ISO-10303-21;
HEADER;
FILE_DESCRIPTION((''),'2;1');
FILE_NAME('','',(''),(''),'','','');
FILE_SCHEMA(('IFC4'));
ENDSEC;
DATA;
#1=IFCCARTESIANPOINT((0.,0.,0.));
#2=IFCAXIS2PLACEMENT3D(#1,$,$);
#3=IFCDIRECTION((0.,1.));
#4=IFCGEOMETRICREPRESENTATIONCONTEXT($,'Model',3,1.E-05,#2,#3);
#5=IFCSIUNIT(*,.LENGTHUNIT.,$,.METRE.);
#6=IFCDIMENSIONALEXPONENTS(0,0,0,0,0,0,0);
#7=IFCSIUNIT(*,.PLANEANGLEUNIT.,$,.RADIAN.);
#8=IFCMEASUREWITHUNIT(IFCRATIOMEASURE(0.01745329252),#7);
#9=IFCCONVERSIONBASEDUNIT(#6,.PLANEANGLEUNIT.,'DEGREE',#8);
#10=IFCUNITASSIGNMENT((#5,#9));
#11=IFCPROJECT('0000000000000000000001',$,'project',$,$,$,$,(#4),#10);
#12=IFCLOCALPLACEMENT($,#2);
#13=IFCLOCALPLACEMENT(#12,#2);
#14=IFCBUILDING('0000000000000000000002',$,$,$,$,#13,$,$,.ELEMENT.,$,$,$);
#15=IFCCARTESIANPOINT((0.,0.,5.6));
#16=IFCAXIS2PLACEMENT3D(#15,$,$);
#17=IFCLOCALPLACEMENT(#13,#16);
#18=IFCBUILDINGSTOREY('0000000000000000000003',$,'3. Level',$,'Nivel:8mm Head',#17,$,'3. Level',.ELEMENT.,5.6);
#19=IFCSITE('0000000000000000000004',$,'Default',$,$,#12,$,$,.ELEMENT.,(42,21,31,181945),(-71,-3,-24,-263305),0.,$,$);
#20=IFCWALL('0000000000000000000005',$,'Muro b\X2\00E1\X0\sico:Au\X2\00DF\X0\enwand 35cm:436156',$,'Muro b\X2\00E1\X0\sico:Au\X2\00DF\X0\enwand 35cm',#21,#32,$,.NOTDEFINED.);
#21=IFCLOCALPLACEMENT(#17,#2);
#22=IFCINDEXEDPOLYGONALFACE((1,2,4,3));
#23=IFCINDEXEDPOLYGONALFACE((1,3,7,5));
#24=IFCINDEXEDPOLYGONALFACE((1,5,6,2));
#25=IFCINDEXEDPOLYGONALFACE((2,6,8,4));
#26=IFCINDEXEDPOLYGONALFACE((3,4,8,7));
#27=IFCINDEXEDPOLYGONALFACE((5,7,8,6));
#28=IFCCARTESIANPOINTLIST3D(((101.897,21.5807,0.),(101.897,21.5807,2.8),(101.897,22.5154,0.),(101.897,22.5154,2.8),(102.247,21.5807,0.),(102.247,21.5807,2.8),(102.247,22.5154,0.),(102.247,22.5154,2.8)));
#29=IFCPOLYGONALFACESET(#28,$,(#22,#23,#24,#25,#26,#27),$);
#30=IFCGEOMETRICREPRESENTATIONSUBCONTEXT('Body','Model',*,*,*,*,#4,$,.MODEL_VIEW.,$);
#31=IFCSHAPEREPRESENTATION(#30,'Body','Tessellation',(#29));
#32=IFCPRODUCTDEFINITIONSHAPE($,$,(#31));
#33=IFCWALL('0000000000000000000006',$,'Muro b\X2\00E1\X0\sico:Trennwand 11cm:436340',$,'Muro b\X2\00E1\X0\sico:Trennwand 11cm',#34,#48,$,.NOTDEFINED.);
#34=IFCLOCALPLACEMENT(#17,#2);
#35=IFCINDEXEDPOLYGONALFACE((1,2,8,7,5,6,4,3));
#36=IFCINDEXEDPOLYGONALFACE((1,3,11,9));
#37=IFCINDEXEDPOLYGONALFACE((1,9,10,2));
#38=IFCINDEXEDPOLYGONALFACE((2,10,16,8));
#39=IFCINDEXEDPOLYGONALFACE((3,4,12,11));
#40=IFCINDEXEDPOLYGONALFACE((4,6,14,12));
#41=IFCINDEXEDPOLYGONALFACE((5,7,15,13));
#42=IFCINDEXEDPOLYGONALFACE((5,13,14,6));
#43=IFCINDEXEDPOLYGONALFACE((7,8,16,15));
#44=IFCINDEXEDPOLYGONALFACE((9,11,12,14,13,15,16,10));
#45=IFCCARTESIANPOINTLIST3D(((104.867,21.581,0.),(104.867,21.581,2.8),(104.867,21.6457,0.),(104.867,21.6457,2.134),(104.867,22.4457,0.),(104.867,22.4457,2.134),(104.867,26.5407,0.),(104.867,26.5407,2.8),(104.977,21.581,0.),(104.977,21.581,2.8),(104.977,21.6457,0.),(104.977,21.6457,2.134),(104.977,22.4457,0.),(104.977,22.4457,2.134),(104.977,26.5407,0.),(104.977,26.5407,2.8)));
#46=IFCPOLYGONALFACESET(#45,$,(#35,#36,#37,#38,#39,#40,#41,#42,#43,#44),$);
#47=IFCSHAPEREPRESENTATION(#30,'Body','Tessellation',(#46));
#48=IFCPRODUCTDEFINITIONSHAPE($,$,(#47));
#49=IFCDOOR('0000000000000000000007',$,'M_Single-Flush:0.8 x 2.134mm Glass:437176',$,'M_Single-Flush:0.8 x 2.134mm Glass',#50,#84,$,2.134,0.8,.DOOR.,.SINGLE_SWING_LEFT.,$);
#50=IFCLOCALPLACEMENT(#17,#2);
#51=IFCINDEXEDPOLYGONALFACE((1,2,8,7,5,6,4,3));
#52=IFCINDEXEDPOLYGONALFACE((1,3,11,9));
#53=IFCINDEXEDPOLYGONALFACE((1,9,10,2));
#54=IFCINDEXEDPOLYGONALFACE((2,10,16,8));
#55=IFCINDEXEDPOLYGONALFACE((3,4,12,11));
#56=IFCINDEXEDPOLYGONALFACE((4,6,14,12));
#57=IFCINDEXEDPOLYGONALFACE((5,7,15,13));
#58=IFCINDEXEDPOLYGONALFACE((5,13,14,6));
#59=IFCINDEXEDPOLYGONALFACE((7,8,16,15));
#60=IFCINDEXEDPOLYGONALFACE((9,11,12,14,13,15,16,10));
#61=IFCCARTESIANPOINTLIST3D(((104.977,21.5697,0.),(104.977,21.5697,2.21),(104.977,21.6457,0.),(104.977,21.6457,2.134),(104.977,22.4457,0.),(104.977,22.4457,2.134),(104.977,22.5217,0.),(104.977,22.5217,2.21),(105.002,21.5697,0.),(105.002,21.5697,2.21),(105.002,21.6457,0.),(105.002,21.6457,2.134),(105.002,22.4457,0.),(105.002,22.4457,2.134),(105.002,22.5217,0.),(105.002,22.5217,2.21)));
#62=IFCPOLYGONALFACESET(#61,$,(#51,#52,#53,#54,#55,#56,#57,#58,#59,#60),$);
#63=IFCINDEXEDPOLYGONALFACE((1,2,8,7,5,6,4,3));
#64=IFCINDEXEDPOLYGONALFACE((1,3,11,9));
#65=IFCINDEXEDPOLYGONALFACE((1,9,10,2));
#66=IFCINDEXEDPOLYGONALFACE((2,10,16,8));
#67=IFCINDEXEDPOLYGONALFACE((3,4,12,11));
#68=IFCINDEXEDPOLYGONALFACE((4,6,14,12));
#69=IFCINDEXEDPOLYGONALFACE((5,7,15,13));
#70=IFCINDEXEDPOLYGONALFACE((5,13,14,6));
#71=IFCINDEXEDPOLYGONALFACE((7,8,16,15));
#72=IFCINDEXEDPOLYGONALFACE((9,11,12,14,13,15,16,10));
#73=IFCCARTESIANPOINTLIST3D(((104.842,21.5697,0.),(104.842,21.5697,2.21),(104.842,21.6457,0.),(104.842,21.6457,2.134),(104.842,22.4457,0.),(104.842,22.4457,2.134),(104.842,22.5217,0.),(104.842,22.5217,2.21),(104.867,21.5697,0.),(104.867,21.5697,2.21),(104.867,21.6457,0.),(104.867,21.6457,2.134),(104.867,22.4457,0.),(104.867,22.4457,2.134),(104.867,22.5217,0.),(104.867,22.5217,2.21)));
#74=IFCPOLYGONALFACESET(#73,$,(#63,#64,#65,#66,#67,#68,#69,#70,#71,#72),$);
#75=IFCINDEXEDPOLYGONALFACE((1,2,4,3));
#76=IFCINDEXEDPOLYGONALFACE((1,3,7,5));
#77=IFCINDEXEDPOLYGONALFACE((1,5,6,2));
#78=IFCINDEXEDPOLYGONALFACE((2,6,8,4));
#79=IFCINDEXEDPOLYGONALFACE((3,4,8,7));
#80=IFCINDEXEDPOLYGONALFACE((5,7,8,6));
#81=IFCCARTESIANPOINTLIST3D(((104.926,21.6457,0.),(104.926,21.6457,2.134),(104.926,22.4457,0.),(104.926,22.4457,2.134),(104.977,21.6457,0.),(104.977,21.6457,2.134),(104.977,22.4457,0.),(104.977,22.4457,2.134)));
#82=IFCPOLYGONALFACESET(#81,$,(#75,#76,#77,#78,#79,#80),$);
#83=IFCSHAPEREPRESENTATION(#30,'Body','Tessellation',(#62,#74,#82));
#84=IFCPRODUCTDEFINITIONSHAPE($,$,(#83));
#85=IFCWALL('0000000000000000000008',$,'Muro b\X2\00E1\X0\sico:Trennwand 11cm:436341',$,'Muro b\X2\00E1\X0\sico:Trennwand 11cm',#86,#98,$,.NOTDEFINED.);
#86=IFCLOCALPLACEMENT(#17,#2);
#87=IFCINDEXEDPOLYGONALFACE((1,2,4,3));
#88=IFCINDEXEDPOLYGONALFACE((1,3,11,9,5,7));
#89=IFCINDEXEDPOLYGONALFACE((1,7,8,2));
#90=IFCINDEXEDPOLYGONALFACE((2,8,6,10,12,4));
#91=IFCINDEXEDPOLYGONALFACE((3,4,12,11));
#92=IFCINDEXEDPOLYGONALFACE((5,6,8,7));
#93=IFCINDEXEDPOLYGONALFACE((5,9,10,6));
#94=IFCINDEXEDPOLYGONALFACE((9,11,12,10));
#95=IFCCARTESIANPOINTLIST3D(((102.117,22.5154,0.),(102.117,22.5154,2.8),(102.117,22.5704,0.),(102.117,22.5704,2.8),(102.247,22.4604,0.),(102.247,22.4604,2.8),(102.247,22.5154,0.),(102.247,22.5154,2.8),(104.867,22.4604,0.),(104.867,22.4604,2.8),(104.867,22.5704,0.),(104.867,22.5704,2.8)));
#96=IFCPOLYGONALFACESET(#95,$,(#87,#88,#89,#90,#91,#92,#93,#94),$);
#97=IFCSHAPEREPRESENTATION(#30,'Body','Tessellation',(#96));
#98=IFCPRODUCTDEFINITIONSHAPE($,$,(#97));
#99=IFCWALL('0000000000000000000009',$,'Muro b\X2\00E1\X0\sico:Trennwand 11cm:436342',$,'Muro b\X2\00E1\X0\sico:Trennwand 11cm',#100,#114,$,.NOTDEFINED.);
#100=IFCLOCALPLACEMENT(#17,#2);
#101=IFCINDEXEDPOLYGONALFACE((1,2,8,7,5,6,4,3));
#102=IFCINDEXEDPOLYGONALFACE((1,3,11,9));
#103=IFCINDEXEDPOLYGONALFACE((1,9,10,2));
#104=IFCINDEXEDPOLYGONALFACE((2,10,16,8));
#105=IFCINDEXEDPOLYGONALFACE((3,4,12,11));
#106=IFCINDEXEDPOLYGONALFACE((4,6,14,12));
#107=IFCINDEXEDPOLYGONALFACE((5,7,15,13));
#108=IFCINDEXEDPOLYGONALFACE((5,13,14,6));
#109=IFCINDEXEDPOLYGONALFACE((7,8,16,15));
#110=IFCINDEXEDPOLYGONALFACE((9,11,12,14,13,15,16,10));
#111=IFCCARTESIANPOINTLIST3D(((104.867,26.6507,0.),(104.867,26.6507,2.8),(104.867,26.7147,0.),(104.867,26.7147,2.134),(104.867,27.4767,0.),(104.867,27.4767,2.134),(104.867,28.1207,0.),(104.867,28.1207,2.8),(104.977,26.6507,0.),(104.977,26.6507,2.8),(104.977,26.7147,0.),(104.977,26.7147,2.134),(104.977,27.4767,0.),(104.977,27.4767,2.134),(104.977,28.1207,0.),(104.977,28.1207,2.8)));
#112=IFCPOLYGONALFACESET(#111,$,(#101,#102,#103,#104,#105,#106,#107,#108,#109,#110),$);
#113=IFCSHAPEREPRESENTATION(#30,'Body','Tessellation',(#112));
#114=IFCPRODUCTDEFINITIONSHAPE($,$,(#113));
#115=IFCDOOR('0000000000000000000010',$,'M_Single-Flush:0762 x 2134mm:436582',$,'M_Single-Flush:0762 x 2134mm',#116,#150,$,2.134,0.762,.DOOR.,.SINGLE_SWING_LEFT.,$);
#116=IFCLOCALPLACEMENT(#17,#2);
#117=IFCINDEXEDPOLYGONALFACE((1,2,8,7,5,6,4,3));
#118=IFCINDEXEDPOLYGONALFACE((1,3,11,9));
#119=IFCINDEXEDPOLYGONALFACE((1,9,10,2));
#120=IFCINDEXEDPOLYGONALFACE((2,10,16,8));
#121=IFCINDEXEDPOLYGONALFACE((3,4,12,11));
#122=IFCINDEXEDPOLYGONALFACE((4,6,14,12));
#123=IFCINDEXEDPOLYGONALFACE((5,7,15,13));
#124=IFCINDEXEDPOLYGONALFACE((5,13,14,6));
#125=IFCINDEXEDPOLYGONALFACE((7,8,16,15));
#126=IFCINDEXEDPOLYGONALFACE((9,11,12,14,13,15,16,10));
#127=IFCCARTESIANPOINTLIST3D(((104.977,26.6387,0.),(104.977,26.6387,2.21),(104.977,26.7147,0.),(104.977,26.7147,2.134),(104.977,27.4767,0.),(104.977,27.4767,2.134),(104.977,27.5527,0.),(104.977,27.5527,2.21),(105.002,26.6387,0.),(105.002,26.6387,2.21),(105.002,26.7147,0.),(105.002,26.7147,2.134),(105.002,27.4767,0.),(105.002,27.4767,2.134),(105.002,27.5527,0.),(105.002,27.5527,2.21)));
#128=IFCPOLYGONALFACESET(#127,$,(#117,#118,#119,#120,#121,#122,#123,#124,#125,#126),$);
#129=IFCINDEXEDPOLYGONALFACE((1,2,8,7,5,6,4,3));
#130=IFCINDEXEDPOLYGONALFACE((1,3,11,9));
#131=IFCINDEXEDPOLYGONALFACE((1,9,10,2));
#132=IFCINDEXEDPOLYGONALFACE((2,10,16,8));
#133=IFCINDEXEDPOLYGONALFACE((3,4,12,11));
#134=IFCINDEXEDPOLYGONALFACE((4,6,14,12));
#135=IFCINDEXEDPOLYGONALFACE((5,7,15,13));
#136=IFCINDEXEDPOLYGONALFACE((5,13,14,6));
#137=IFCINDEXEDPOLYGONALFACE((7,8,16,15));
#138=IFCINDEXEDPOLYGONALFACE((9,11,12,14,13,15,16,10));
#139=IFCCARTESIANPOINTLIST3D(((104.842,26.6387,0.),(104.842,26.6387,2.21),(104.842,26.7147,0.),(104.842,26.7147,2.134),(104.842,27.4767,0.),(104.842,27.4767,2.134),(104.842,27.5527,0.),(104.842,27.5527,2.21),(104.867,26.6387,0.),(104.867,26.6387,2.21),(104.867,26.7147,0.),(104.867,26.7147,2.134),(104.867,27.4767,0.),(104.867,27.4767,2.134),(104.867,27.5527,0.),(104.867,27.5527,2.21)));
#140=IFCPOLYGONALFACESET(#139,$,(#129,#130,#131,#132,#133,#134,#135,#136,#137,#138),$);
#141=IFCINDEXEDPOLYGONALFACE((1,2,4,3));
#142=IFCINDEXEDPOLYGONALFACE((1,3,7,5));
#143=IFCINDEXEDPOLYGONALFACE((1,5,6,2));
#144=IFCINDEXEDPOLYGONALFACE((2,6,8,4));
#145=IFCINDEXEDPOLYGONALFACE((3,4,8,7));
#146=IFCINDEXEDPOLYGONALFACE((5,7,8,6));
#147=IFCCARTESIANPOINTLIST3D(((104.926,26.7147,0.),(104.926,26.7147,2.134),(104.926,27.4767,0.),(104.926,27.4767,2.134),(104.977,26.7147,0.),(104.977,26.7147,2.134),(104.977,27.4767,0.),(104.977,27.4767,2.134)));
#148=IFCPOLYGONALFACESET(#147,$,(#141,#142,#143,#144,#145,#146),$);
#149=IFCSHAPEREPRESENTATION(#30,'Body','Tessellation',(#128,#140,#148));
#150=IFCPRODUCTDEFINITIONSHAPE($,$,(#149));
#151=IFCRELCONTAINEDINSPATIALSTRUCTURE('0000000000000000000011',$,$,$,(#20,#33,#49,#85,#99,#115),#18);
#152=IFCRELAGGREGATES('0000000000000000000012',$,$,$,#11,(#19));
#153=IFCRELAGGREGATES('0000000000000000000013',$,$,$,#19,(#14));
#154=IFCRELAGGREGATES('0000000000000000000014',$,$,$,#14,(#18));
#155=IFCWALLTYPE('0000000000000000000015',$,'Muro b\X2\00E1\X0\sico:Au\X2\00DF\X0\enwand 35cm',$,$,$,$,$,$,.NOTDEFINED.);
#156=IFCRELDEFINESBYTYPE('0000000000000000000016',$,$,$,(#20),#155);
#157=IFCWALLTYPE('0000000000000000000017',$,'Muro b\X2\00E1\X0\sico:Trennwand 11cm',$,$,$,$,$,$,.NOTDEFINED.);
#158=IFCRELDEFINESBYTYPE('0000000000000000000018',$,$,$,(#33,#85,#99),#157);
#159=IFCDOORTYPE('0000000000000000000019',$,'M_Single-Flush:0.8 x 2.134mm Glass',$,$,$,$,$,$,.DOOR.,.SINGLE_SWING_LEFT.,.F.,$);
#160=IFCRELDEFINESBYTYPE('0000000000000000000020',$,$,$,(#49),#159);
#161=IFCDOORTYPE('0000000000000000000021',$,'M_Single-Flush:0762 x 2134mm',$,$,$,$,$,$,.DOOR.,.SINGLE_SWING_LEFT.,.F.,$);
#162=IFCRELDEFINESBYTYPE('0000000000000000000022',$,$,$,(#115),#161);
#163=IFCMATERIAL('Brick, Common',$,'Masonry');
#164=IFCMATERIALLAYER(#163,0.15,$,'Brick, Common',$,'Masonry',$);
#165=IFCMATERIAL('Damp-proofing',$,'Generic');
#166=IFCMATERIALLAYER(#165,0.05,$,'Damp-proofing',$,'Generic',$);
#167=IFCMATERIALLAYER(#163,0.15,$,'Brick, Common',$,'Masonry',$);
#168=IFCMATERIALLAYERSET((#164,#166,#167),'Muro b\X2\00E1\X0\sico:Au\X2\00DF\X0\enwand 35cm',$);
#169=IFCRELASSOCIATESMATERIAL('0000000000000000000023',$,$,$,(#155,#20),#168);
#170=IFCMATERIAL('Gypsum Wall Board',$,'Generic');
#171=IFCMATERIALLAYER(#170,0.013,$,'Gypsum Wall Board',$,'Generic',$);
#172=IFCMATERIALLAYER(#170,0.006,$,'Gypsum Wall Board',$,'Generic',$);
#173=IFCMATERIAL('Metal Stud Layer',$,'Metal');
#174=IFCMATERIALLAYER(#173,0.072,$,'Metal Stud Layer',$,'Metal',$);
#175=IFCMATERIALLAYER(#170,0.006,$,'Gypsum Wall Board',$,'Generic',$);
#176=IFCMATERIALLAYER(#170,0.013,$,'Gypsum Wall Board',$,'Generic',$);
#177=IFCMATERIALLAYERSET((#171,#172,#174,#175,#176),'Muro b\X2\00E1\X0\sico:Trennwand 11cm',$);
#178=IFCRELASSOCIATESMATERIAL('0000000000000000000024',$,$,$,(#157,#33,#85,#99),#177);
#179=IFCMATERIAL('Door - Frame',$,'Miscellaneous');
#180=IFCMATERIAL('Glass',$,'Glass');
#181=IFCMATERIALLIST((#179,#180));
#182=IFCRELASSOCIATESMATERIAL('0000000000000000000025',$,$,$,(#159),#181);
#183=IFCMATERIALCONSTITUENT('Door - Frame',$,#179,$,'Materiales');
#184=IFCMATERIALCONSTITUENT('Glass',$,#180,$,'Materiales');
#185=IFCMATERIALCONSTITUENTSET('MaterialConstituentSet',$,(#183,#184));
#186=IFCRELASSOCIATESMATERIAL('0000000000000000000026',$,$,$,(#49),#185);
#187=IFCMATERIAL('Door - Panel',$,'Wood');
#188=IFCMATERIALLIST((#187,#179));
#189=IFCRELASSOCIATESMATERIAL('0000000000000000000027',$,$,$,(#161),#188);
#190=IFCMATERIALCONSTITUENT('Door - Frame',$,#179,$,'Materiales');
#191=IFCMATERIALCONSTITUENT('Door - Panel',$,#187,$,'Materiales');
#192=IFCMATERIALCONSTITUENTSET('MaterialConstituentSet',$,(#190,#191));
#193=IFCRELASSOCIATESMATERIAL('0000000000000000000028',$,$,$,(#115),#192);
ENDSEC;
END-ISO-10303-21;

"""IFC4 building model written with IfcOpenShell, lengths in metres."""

from ifc_helpers import new_model, entity, si_unit, converted_unit, direction, frame, frame_2d, origin, origin_2d_with_axis, place, context, subcontext, project, spatial, polyline, rectangle, outline, extrude, source, transform, mapped, material, material_list, layer, layer_set, layer_usage, constituent, constituent_set, type_object, type_shapes, element, fill, save


model = new_model("IFC4")

# Units and contexts
model_context = context("Model", 3, precision=1e-05, world=origin(), true_north=direction((0.0, 1.0)))
body_context = subcontext(model_context, "Body", "Model", "MODEL_VIEW")
ifc_project = project(units=[si_unit("LENGTHUNIT", "METRE"), converted_unit("PLANEANGLEUNIT", "DEGREE", entity("IfcRatioMeasure", 0.01745329252), si_unit("PLANEANGLEUNIT", "RADIAN"), dimensions=[0, 0, 0, 0, 0, 0, 0])], contexts=[model_context])

# Site, building, storey
site_placement = place(None, origin())
site = spatial("IfcSite", under=ifc_project, at=site_placement, Name="Default", CompositionType="ELEMENT", RefLatitude=(42, 21, 31, 181945), RefLongitude=(-71, -3, -24, -263305), RefElevation=0.0)
building_placement = place(site_placement, origin())
building = spatial("IfcBuilding", under=site, at=building_placement, CompositionType="ELEMENT")
storey_placement = place(building_placement, frame((0.0, 0.0, 5.6)))
storey = spatial("IfcBuildingStorey", under=building, at=storey_placement, Name="3. Level", ObjectType="Nivel:8mm Head", LongName="3. Level", CompositionType="ELEMENT", Elevation=5.6)

# Wall
ifc_material_1 = material(Name="Brick, Common", Category="Masonry")
ifc_layer_1 = layer(ifc_material_1, 0.15, Name="Brick, Common", Category="Masonry")
ifc_material_2 = material(Name="Damp-proofing", Category="Generic")
ifc_layer_2 = layer(ifc_material_2, 0.05, Name="Damp-proofing", Category="Generic")
ifc_layer_3 = layer(ifc_material_1, 0.15, Name="Brick, Common", Category="Masonry")
ifc_layer_set_1 = layer_set([ifc_layer_1, ifc_layer_2, ifc_layer_3], Name="Muro básico:Außenwand 35cm")
ifc_layer_usage_1 = layer_usage(ifc_layer_set_1, "AXIS2", "NEGATIVE", 0.175)
wall_type_1 = type_object("IfcWallType", Name="Muro básico:Außenwand 35cm", PredefinedType="NOTDEFINED", material=ifc_layer_set_1)
wall_1_placement = place(storey_placement, frame((102.072, 21.5807, 0.0), z_axis=(0.0, 0.0, 1.0), x_axis=(0.0, 1.0, 0.0)))
element("IfcWall", 1, at=wall_1_placement, inside=storey, type_object=wall_type_1, material=ifc_layer_usage_1, Name="Muro básico:Außenwand 35cm:436156", ObjectType="Muro básico:Außenwand 35cm", PredefinedType="NOTDEFINED", context=body_context, shape_type="SweptSolid", body=[
    extrude(rectangle(XDim=0.9347, YDim=0.35, at=frame_2d((0.4673, 0.0), x_axis=(-1.0, 0.0))), origin(), (0.0, 0.0, 1.0), 2.8),
])

# Wall, opening, door
ifc_material_3 = material(Name="Gypsum Wall Board", Category="Generic")
ifc_layer_4 = layer(ifc_material_3, 0.013, Name="Gypsum Wall Board", Category="Generic")
ifc_layer_5 = layer(ifc_material_3, 0.006, Name="Gypsum Wall Board", Category="Generic")
ifc_material_4 = material(Name="Metal Stud Layer", Category="Metal")
ifc_layer_6 = layer(ifc_material_4, 0.072, Name="Metal Stud Layer", Category="Metal")
ifc_layer_7 = layer(ifc_material_3, 0.006, Name="Gypsum Wall Board", Category="Generic")
ifc_layer_8 = layer(ifc_material_3, 0.013, Name="Gypsum Wall Board", Category="Generic")
ifc_layer_set_2 = layer_set([ifc_layer_4, ifc_layer_5, ifc_layer_6, ifc_layer_7, ifc_layer_8], Name="Muro básico:Trennwand 11cm")
ifc_layer_usage_2 = layer_usage(ifc_layer_set_2, "AXIS2", "NEGATIVE", 0.055)
wall_type_2 = type_object("IfcWallType", Name="Muro básico:Trennwand 11cm", PredefinedType="NOTDEFINED", material=ifc_layer_set_2)
wall_2_placement = place(storey_placement, frame((104.922, 26.5407, 0.0), z_axis=(0.0, 0.0, 1.0), x_axis=(0.0, -1.0, 0.0)))
wall_2 = element("IfcWall", 2, at=wall_2_placement, inside=storey, type_object=wall_type_2, material=ifc_layer_usage_2, Name="Muro básico:Trennwand 11cm:436340", ObjectType="Muro básico:Trennwand 11cm", PredefinedType="NOTDEFINED", context=body_context, shape_type="SweptSolid", body=[
    extrude(rectangle(XDim=4.9597, YDim=0.11, at=frame_2d((2.4798, 0.0), x_axis=(-1.0, 0.0))), origin(), (0.0, 0.0, 1.0), 2.8),
])
opening_1_placement = place(wall_2_placement, frame((4.095, -0.055, 0.0)))
opening_1 = element("IfcOpeningElement", 3, at=opening_1_placement, cuts=wall_2, ObjectType="Opening", PredefinedType="OPENING", context=body_context, shape_type="SweptSolid", body=[
    extrude(rectangle(XDim=0.8, YDim=2.134, at=frame_2d((1.067, 0.4), x_axis=(0.0, -1.0))), frame((0.0, 0.0, 0.0), z_axis=(0.0, 1.0, 0.0), x_axis=(0.0, 0.0, 1.0)), (0.0, 0.0, 1.0), 0.11),
])
ifc_material_5 = material(Name="Door - Frame", Category="Miscellaneous")
ifc_constituent_1 = constituent(ifc_material_5, Name="Door - Frame", Category="Materiales")
ifc_material_6 = material(Name="Glass", Category="Glass")
ifc_constituent_2 = constituent(ifc_material_6, Name="Glass", Category="Materiales")
ifc_constituent_set_1 = constituent_set(constituents=[ifc_constituent_1, ifc_constituent_2], Name="MaterialConstituentSet")
ifc_material_list_1 = material_list([ifc_material_5, ifc_material_6])
door_type_1 = type_object("IfcDoorType", Name="M_Single-Flush:0.8 x 2.134mm Glass", OperationType="SINGLE_SWING_LEFT", ParameterTakesPrecedence=False, PredefinedType="DOOR", material=ifc_material_list_1)
shared_shape_1 = source(origin(), body_context, "Body", "SweptSolid", [
    extrude(outline(polyline([(-0.476, -1.124), (0.476, -1.124), (0.476, 1.086), (0.4, 1.086), (0.4, -1.048), (-0.4, -1.048), (-0.4, 1.086), (-0.476, 1.086), (-0.476, -1.124)])), frame((0.4, 0.135, 1.086), z_axis=(0.0, -1.0, 0.0), x_axis=(-1.0, 0.0, 0.0)), (0.0, 0.0, 1.0), 0.025),
    extrude(outline(polyline([(-1.124, -0.476), (1.086, -0.476), (1.086, -0.4), (-1.048, -0.4), (-1.048, 0.4), (1.086, 0.4), (1.086, 0.476), (-1.124, 0.476), (-1.124, -0.476)])), frame((0.4, 0.0, 1.086), z_axis=(0.0, -1.0, 0.0), x_axis=(0.0, 0.0, -1.0)), (0.0, 0.0, 1.0), 0.025),
    extrude(rectangle(XDim=0.8, YDim=0.051, at=origin_2d_with_axis()), frame((0.4, 0.0845, 0.0)), (0.0, 0.0, 1.0), 2.134),
])
type_shapes(door_type_1, [shared_shape_1])
door_1_placement = place(opening_1_placement, origin())
door_1 = element("IfcDoor", 4, at=door_1_placement, inside=storey, type_object=door_type_1, material=ifc_constituent_set_1, Name="M_Single-Flush:0.8 x 2.134mm Glass:437176", ObjectType="M_Single-Flush:0.8 x 2.134mm Glass", OperationType="SINGLE_SWING_LEFT", OverallHeight=2.134, OverallWidth=0.8, PredefinedType="DOOR", context=body_context, shape_type="MappedRepresentation", body=[
    mapped(shared_shape_1, transform((0.0, 0.0, 0.0), scale=1.0)),
])
fill(opening_1, door_1)

# Wall
ifc_layer_usage_3 = layer_usage(ifc_layer_set_2, "AXIS2", "NEGATIVE", 0.055)
wall_3_placement = place(storey_placement, frame((104.867, 22.5154, 0.0), z_axis=(0.0, 0.0, 1.0), x_axis=(-1.0, 0.0, 0.0)))
element("IfcWall", 5, at=wall_3_placement, inside=storey, type_object=wall_type_2, material=ifc_layer_usage_3, Name="Muro básico:Trennwand 11cm:436341", ObjectType="Muro básico:Trennwand 11cm", PredefinedType="NOTDEFINED", context=body_context, shape_type="SweptSolid", body=[
    extrude(outline(polyline([(2.75, -0.055), (2.75, 0.0), (2.62, 0.0), (2.62, 0.055), (0.0, 0.055), (0.0, -0.055), (2.75, -0.055)])), origin(), (0.0, 0.0, 1.0), 2.8),
])

# Wall, opening, door
ifc_layer_usage_4 = layer_usage(ifc_layer_set_2, "AXIS2", "NEGATIVE", 0.055)
wall_4_placement = place(storey_placement, frame((104.922, 26.6507, 0.0), z_axis=(0.0, 0.0, 1.0), x_axis=(0.0, 1.0, 0.0)))
wall_4 = element("IfcWall", 6, at=wall_4_placement, inside=storey, type_object=wall_type_2, material=ifc_layer_usage_4, Name="Muro básico:Trennwand 11cm:436342", ObjectType="Muro básico:Trennwand 11cm", PredefinedType="NOTDEFINED", context=body_context, shape_type="SweptSolid", body=[
    extrude(rectangle(XDim=1.47, YDim=0.11, at=frame_2d((0.735, 0.0), x_axis=(-1.0, 0.0))), origin(), (0.0, 0.0, 1.0), 2.8),
])
opening_2_placement = place(wall_4_placement, frame((0.826, 0.055, 0.0)))
opening_2 = element("IfcOpeningElement", 7, at=opening_2_placement, cuts=wall_4, ObjectType="Opening", PredefinedType="OPENING", context=body_context, shape_type="SweptSolid", body=[
    extrude(rectangle(XDim=0.762, YDim=2.134, at=frame_2d((1.067, 0.381), x_axis=(0.0, -1.0))), frame((0.0, 0.0, 0.0), z_axis=(0.0, -1.0, 0.0), x_axis=(0.0, 0.0, 1.0)), (0.0, 0.0, 1.0), 0.11),
])
ifc_constituent_3 = constituent(ifc_material_5, Name="Door - Frame", Category="Materiales")
ifc_material_7 = material(Name="Door - Panel", Category="Wood")
ifc_constituent_4 = constituent(ifc_material_7, Name="Door - Panel", Category="Materiales")
ifc_constituent_set_2 = constituent_set(constituents=[ifc_constituent_3, ifc_constituent_4], Name="MaterialConstituentSet")
ifc_material_list_2 = material_list([ifc_material_7, ifc_material_5])
door_type_2 = type_object("IfcDoorType", Name="M_Single-Flush:0762 x 2134mm", OperationType="SINGLE_SWING_LEFT", ParameterTakesPrecedence=False, PredefinedType="DOOR", material=ifc_material_list_2)
shared_shape_2 = source(origin(), body_context, "Body", "SweptSolid", [
    extrude(outline(polyline([(-0.457, -1.124), (0.457, -1.124), (0.457, 1.086), (0.381, 1.086), (0.381, -1.048), (-0.381, -1.048), (-0.381, 1.086), (-0.457, 1.086), (-0.457, -1.124)])), frame((0.381, 0.135, 1.086), z_axis=(0.0, -1.0, 0.0), x_axis=(-1.0, 0.0, 0.0)), (0.0, 0.0, 1.0), 0.025),
    extrude(outline(polyline([(-1.124, -0.457), (1.086, -0.457), (1.086, -0.381), (-1.048, -0.381), (-1.048, 0.381), (1.086, 0.381), (1.086, 0.457), (-1.124, 0.457), (-1.124, -0.457)])), frame((0.381, 0.0, 1.086), z_axis=(0.0, -1.0, 0.0), x_axis=(0.0, 0.0, -1.0)), (0.0, 0.0, 1.0), 0.025),
    extrude(rectangle(XDim=0.762, YDim=0.051, at=origin_2d_with_axis()), frame((0.381, 0.0845, 0.0)), (0.0, 0.0, 1.0), 2.134),
])
type_shapes(door_type_2, [shared_shape_2])
door_2_placement = place(opening_2_placement, frame((0.0, 0.0, 0.0), z_axis=(0.0, 0.0, 1.0), x_axis=(-1.0, 0.0, 0.0)))
door_2 = element("IfcDoor", 8, at=door_2_placement, inside=storey, type_object=door_type_2, material=ifc_constituent_set_2, Name="M_Single-Flush:0762 x 2134mm:436582", ObjectType="M_Single-Flush:0762 x 2134mm", OperationType="SINGLE_SWING_LEFT", OverallHeight=2.134, OverallWidth=0.762, PredefinedType="DOOR", context=body_context, shape_type="MappedRepresentation", body=[
    mapped(shared_shape_2, transform((0.0, 0.0, 0.0), scale=1.0)),
])
fill(opening_2, door_2)

save(model, "model.ifc")
